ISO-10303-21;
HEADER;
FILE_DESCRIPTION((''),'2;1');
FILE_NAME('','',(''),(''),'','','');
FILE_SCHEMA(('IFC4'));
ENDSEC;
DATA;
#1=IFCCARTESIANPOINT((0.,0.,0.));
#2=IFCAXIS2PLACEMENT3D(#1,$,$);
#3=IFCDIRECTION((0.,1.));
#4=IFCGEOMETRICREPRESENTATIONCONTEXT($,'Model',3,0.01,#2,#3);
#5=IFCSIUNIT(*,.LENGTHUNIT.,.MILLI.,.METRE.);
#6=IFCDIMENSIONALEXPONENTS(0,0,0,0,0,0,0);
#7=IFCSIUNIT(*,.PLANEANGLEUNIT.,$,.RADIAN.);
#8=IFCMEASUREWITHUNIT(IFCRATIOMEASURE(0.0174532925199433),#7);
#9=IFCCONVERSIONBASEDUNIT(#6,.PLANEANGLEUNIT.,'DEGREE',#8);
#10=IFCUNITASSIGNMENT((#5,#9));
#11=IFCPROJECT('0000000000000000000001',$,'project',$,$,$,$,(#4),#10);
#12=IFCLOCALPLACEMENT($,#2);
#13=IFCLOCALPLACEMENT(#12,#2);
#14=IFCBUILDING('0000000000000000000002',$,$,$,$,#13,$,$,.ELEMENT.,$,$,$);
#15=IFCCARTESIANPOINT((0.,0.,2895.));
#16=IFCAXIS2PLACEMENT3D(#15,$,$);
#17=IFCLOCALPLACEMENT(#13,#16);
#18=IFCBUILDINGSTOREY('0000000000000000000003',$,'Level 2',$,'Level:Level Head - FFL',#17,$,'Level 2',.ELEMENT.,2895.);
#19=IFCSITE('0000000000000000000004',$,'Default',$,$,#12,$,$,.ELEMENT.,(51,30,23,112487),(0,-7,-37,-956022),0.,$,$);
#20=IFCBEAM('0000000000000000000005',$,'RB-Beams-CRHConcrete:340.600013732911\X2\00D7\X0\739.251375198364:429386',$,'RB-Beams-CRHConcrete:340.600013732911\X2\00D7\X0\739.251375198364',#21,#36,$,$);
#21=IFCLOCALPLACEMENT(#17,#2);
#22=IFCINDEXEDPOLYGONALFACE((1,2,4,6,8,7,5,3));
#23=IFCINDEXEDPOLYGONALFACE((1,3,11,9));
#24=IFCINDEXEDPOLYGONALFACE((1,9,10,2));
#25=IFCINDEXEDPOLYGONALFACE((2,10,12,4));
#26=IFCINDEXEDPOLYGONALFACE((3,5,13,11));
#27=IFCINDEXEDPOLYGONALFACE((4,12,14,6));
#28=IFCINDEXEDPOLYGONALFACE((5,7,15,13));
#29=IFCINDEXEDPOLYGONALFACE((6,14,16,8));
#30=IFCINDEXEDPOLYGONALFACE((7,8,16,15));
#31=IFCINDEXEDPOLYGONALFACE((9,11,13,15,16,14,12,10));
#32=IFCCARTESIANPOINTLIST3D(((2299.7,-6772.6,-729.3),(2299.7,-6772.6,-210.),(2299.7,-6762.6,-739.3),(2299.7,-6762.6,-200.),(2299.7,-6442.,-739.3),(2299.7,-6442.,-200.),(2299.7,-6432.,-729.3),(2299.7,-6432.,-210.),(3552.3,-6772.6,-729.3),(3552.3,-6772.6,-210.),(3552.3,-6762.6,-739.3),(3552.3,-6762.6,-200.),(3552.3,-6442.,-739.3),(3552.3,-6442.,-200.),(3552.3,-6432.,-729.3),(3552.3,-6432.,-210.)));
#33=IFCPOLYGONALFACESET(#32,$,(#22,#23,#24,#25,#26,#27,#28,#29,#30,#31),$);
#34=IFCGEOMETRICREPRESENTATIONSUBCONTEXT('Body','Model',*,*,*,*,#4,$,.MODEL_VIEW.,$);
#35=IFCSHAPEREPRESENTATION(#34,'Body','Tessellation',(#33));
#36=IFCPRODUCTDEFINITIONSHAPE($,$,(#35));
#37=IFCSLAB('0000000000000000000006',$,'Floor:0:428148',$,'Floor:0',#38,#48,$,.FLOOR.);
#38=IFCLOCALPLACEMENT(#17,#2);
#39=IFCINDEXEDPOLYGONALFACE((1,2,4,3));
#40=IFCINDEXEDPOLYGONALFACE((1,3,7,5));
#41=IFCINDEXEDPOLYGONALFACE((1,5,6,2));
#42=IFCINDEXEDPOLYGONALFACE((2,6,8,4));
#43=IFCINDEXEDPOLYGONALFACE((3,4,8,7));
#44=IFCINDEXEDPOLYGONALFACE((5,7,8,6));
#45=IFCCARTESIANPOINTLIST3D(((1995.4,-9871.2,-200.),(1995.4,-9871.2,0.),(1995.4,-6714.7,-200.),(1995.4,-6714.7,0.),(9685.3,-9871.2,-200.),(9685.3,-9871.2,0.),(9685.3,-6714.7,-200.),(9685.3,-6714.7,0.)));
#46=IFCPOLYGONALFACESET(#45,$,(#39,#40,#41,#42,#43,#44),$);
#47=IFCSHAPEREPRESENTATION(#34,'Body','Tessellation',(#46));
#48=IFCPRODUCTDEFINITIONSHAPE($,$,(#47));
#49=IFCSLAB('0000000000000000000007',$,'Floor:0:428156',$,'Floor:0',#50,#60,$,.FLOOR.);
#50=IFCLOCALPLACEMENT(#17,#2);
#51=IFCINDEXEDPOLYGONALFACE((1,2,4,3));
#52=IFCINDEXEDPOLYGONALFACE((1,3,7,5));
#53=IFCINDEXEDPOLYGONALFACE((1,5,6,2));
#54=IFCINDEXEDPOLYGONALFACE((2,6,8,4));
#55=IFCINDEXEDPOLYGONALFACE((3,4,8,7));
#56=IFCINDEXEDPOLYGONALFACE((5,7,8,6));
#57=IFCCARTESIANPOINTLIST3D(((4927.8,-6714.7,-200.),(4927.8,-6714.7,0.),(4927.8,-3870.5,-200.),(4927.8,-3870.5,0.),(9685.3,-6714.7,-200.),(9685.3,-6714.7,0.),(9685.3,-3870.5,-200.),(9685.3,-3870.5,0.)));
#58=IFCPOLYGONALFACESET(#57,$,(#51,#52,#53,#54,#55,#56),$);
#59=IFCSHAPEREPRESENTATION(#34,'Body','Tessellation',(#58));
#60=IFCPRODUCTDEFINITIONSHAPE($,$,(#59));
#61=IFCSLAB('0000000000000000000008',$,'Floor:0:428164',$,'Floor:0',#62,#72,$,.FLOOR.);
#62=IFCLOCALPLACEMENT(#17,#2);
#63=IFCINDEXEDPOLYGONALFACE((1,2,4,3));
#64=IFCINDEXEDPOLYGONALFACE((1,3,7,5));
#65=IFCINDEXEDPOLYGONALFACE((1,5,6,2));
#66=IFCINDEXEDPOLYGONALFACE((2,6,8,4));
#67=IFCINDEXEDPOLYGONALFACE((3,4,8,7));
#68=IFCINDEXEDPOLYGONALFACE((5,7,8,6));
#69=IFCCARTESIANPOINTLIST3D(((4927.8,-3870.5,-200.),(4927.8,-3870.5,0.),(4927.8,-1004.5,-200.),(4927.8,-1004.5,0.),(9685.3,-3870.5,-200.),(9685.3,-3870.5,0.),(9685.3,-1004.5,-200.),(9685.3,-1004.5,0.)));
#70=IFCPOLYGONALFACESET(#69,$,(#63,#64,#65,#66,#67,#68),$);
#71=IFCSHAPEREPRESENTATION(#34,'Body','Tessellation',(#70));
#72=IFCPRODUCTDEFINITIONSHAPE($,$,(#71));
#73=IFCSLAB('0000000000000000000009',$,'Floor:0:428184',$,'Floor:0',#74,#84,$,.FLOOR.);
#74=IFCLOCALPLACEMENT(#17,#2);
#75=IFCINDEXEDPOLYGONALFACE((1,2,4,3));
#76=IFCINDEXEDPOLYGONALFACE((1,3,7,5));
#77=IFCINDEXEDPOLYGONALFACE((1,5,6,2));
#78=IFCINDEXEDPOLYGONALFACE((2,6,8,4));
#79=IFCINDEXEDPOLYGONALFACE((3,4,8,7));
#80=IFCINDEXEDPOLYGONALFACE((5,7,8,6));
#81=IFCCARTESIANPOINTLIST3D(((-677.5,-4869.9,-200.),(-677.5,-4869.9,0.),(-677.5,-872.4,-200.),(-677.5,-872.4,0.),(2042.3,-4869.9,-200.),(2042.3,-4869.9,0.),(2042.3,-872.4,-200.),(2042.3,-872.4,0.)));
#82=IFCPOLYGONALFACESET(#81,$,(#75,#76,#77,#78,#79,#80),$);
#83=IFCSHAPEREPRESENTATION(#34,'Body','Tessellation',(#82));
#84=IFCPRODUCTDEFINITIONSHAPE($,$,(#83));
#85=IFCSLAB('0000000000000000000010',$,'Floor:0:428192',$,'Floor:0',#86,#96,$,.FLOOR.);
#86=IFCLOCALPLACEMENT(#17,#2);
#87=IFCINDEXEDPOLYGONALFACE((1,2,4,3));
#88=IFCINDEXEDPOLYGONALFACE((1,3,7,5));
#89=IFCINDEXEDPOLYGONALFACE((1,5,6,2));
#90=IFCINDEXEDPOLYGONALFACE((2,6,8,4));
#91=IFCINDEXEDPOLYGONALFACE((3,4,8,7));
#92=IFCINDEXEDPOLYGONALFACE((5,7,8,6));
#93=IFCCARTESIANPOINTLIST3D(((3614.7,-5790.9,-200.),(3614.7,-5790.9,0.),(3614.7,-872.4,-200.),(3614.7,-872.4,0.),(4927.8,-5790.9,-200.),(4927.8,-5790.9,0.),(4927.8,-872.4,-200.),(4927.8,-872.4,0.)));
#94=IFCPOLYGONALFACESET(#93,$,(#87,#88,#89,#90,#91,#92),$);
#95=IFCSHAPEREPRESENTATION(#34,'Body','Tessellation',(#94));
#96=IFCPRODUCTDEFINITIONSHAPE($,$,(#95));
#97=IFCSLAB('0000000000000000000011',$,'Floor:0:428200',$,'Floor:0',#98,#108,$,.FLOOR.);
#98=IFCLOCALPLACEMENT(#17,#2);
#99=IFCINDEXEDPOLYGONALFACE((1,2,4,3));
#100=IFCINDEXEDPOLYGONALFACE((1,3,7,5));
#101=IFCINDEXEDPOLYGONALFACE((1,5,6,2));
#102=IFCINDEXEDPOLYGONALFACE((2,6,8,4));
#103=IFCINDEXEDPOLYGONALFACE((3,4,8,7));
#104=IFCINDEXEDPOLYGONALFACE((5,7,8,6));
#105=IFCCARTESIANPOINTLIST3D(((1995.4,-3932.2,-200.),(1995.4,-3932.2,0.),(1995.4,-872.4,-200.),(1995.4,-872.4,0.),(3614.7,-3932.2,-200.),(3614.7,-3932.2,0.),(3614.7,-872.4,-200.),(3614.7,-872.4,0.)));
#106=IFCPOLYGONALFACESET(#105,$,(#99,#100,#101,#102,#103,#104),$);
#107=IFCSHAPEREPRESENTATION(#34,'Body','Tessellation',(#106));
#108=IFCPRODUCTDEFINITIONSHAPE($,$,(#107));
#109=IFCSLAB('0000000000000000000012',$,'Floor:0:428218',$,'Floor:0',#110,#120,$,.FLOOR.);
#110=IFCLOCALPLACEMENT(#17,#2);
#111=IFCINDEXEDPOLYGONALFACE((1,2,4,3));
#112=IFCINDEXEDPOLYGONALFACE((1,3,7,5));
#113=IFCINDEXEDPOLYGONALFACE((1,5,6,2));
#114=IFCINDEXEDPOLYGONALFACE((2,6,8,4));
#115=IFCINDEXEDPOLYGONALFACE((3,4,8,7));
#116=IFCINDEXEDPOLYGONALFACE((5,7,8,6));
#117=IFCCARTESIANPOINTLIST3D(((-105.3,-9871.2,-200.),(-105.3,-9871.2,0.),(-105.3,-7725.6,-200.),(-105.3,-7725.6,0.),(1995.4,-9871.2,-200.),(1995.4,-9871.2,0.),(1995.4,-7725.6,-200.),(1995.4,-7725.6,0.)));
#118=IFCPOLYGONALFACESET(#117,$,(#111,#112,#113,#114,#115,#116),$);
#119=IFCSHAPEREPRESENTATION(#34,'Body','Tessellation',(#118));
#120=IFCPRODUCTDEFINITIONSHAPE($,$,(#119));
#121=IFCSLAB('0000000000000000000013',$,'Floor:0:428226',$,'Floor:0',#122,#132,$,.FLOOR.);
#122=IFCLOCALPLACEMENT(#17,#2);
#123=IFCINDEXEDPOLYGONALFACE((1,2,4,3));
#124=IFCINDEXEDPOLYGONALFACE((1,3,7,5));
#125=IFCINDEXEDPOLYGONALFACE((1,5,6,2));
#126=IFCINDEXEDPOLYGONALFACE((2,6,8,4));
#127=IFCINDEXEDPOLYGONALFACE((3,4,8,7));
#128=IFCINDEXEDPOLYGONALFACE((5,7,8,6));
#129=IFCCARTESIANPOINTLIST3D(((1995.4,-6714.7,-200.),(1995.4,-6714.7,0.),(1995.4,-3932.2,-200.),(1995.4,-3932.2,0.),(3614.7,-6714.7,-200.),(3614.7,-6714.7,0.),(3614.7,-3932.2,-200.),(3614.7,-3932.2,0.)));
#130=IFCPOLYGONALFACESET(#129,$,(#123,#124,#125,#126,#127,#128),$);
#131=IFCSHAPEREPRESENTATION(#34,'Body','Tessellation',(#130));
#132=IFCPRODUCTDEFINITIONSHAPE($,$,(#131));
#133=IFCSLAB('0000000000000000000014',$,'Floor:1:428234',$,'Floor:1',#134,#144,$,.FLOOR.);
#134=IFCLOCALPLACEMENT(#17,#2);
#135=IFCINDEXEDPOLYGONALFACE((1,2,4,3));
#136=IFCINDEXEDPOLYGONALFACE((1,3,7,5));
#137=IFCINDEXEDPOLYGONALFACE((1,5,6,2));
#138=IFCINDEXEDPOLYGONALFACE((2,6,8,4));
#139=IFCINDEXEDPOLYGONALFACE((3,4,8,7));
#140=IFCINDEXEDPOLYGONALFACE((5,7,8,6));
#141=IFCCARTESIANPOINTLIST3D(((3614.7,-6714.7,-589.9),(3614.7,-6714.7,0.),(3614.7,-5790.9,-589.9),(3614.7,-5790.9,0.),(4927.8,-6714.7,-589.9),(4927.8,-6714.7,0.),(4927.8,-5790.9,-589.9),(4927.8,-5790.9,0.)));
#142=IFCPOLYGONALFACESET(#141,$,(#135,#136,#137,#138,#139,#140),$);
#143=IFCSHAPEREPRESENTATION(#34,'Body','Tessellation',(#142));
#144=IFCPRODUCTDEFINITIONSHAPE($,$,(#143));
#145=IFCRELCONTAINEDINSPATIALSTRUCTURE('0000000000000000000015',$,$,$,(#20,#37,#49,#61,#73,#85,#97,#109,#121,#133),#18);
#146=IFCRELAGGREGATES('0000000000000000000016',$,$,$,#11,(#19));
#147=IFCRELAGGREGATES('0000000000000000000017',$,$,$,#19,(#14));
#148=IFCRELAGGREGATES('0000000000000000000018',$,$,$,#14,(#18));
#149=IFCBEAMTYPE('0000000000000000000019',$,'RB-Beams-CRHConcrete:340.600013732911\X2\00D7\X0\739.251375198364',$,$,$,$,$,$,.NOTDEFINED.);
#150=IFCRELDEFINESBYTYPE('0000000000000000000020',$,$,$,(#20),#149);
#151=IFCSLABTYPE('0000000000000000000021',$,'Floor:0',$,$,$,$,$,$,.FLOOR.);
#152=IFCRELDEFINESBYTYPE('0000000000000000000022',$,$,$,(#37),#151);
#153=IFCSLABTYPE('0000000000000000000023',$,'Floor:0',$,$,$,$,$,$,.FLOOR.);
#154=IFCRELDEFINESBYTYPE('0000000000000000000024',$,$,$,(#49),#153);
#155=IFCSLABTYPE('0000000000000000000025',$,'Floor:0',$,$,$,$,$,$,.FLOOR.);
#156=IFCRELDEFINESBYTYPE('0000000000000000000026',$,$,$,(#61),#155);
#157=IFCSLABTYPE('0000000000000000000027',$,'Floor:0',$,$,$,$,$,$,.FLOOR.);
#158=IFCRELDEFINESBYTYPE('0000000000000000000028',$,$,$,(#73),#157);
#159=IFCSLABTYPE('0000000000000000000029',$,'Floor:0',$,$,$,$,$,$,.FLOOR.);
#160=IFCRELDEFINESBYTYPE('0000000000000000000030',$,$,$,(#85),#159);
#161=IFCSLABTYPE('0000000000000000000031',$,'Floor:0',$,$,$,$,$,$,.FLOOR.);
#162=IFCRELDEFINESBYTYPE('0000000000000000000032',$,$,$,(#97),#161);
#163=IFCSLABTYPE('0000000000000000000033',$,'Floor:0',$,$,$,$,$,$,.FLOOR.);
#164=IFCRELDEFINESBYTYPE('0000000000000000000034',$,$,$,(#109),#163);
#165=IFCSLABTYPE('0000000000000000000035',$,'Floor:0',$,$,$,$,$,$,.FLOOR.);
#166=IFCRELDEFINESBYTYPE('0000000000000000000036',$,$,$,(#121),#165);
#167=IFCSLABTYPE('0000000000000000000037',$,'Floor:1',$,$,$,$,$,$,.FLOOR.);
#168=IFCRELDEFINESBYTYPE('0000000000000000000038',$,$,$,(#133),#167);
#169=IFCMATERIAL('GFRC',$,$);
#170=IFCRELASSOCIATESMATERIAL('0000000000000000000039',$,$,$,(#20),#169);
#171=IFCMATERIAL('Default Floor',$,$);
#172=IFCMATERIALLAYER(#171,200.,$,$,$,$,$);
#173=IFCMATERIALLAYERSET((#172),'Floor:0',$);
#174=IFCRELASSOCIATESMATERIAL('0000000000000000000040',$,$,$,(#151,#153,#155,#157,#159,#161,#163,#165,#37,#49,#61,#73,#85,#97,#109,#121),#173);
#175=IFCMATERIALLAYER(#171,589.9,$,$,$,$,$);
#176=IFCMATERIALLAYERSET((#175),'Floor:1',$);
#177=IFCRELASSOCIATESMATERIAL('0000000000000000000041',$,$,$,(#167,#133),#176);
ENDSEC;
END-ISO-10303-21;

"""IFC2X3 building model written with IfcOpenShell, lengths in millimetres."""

from ifc_helpers import new_model, entity, si_unit, converted_unit, direction, frame, frame_2d, origin, place, context, subcontext, project, spatial, polyline, rectangle, outline, extrude, material, layer, layer_set, layer_usage, type_object, element, save


model = new_model("IFC2X3")

# Units and contexts
model_context = context("Model", 3, precision=0.01, world=origin(), true_north=direction((0.0, 1.0)))
body_context = subcontext(model_context, "Body", "Model", "MODEL_VIEW")
ifc_project = project(units=[si_unit("LENGTHUNIT", "METRE", prefix="MILLI"), converted_unit("PLANEANGLEUNIT", "DEGREE", entity("IfcRatioMeasure", 0.0174532925199433), si_unit("PLANEANGLEUNIT", "RADIAN"), dimensions=[0, 0, 0, 0, 0, 0, 0])], contexts=[model_context])

# Site, building, storey
site_placement = place(None, origin())
site = spatial("IfcSite", under=ifc_project, at=site_placement, Name="Default", CompositionType="ELEMENT", RefLatitude=(51, 30, 23, 112487), RefLongitude=(0, -7, -37, -956022), RefElevation=0.0)
building_placement = place(site_placement, origin())
building = spatial("IfcBuilding", under=site, at=building_placement, CompositionType="ELEMENT")
storey_placement = place(building_placement, frame((0.0, 0.0, 2895.0)))
storey = spatial("IfcBuildingStorey", under=building, at=storey_placement, Name="Level 2", ObjectType="Level:Level Head - FFL", LongName="Level 2", CompositionType="ELEMENT", Elevation=2895.0)

# Beam
ifc_material_1 = material(Name="GFRC")
beam_type_1 = type_object("IfcBeamType", Name="RB-Beams-CRHConcrete:340.600013732911×739.251375198364", PredefinedType="NOTDEFINED")
beam_1_placement = place(storey_placement, frame((2299.7, -6602.3, -200.0)))
element("IfcBeam", 1, at=beam_1_placement, inside=storey, type_object=beam_type_1, material=ifc_material_1, Name="RB-Beams-CRHConcrete:340.600013732911×739.251375198364:429386", ObjectType="RB-Beams-CRHConcrete:340.600013732911×739.251375198364", context=body_context, shape_type="SweptSolid", body=[
    extrude(outline(polyline([(-259.6, -170.3), (259.6, -170.3), (269.6, -160.3), (269.6, 160.3), (259.6, 170.3), (-259.6, 170.3), (-269.6, 160.3), (-269.6, -160.3), (-259.6, -170.3)])), frame((0.0, 0.0, -269.6), z_axis=(1.0, 0.0, 0.0), x_axis=(0.0, 0.0, -1.0)), (0.0, 0.0, 1.0), 1252.6),
])

# Slabs
ifc_material_2 = material(Name="Default Floor")
ifc_layer_1 = layer(ifc_material_2, 200.0)
ifc_layer_set_1 = layer_set([ifc_layer_1], Name="Floor:0")
ifc_layer_usage_1 = layer_usage(ifc_layer_set_1, "AXIS3", "POSITIVE", 0.0)
slab_type_1 = type_object("IfcSlabType", Name="Floor:0", PredefinedType="FLOOR", material=ifc_layer_set_1)
slab_1_placement = place(storey_placement, origin())
element("IfcSlab", 2, at=slab_1_placement, inside=storey, type_object=slab_type_1, material=ifc_layer_usage_1, Name="Floor:0:428148", ObjectType="Floor:0", PredefinedType="FLOOR", context=body_context, shape_type="SweptSolid", body=[
    extrude(rectangle(XDim=3156.5, YDim=7689.9, at=frame_2d((0.0, 0.0), x_axis=(1.0, 0.0))), frame((5840.3, -8293.0, 0.0), z_axis=(0.0, 0.0, -1.0), x_axis=(0.0, 1.0, 0.0)), (0.0, 0.0, 1.0), 200.0),
])
ifc_layer_usage_2 = layer_usage(ifc_layer_set_1, "AXIS3", "POSITIVE", 0.0)
slab_type_2 = type_object("IfcSlabType", Name="Floor:0", PredefinedType="FLOOR", material=ifc_layer_set_1)
slab_2_placement = place(storey_placement, origin())
element("IfcSlab", 3, at=slab_2_placement, inside=storey, type_object=slab_type_2, material=ifc_layer_usage_2, Name="Floor:0:428156", ObjectType="Floor:0", PredefinedType="FLOOR", context=body_context, shape_type="SweptSolid", body=[
    extrude(rectangle(XDim=2844.3, YDim=4757.5, at=frame_2d((0.0, 0.0), x_axis=(1.0, 0.0))), frame((7306.5, -5292.6, 0.0), z_axis=(0.0, 0.0, -1.0), x_axis=(0.0, 1.0, 0.0)), (0.0, 0.0, 1.0), 200.0),
])
ifc_layer_usage_3 = layer_usage(ifc_layer_set_1, "AXIS3", "POSITIVE", 0.0)
slab_type_3 = type_object("IfcSlabType", Name="Floor:0", PredefinedType="FLOOR", material=ifc_layer_set_1)
slab_3_placement = place(storey_placement, origin())
element("IfcSlab", 4, at=slab_3_placement, inside=storey, type_object=slab_type_3, material=ifc_layer_usage_3, Name="Floor:0:428164", ObjectType="Floor:0", PredefinedType="FLOOR", context=body_context, shape_type="SweptSolid", body=[
    extrude(rectangle(XDim=2866.0, YDim=4757.5, at=frame_2d((0.0, 0.0), x_axis=(1.0, 0.0))), frame((7306.5, -2437.5, 0.0), z_axis=(0.0, 0.0, -1.0), x_axis=(0.0, 1.0, 0.0)), (0.0, 0.0, 1.0), 200.0),
])
ifc_layer_2 = layer(ifc_material_2, 589.9)
ifc_layer_set_2 = layer_set([ifc_layer_2], Name="Floor:1")
ifc_layer_usage_4 = layer_usage(ifc_layer_set_1, "AXIS3", "POSITIVE", 0.0)
slab_type_4 = type_object("IfcSlabType", Name="Floor:0", PredefinedType="FLOOR", material=ifc_layer_set_1)
slab_4_placement = place(storey_placement, origin())
element("IfcSlab", 5, at=slab_4_placement, inside=storey, type_object=slab_type_4, material=ifc_layer_usage_4, Name="Floor:0:428184", ObjectType="Floor:0", PredefinedType="FLOOR", context=body_context, shape_type="SweptSolid", body=[
    extrude(rectangle(XDim=3997.6, YDim=2719.8, at=frame_2d((0.0, 0.0), x_axis=(1.0, 0.0))), frame((682.4, -2871.2, 0.0), z_axis=(0.0, 0.0, -1.0), x_axis=(0.0, 1.0, 0.0)), (0.0, 0.0, 1.0), 200.0),
])
ifc_layer_usage_5 = layer_usage(ifc_layer_set_1, "AXIS3", "POSITIVE", 0.0)
slab_type_5 = type_object("IfcSlabType", Name="Floor:0", PredefinedType="FLOOR", material=ifc_layer_set_1)
slab_5_placement = place(storey_placement, origin())
element("IfcSlab", 6, at=slab_5_placement, inside=storey, type_object=slab_type_5, material=ifc_layer_usage_5, Name="Floor:0:428192", ObjectType="Floor:0", PredefinedType="FLOOR", context=body_context, shape_type="SweptSolid", body=[
    extrude(rectangle(XDim=4918.5, YDim=1313.0, at=frame_2d((0.0, 0.0), x_axis=(1.0, 0.0))), frame((4271.2, -3331.6, 0.0), z_axis=(0.0, 0.0, -1.0), x_axis=(0.0, 1.0, 0.0)), (0.0, 0.0, 1.0), 200.0),
])
ifc_layer_usage_6 = layer_usage(ifc_layer_set_1, "AXIS3", "POSITIVE", 0.0)
slab_type_6 = type_object("IfcSlabType", Name="Floor:0", PredefinedType="FLOOR", material=ifc_layer_set_1)
slab_6_placement = place(storey_placement, origin())
element("IfcSlab", 7, at=slab_6_placement, inside=storey, type_object=slab_type_6, material=ifc_layer_usage_6, Name="Floor:0:428200", ObjectType="Floor:0", PredefinedType="FLOOR", context=body_context, shape_type="SweptSolid", body=[
    extrude(rectangle(XDim=3059.8, YDim=1619.3, at=frame_2d((0.0, 0.0), x_axis=(1.0, 0.0))), frame((2805.1, -2402.3, 0.0), z_axis=(0.0, 0.0, -1.0), x_axis=(0.0, 1.0, 0.0)), (0.0, 0.0, 1.0), 200.0),
])
ifc_layer_usage_7 = layer_usage(ifc_layer_set_1, "AXIS3", "POSITIVE", 0.0)
slab_type_7 = type_object("IfcSlabType", Name="Floor:0", PredefinedType="FLOOR", material=ifc_layer_set_1)
slab_7_placement = place(storey_placement, origin())
element("IfcSlab", 8, at=slab_7_placement, inside=storey, type_object=slab_type_7, material=ifc_layer_usage_7, Name="Floor:0:428218", ObjectType="Floor:0", PredefinedType="FLOOR", context=body_context, shape_type="SweptSolid", body=[
    extrude(rectangle(XDim=2145.6, YDim=2100.8, at=frame_2d((0.0, 0.0), x_axis=(1.0, 0.0))), frame((945.0, -8798.4, 0.0), z_axis=(0.0, 0.0, -1.0), x_axis=(0.0, 1.0, 0.0)), (0.0, 0.0, 1.0), 200.0),
])
ifc_layer_usage_8 = layer_usage(ifc_layer_set_1, "AXIS3", "POSITIVE", 0.0)
slab_type_8 = type_object("IfcSlabType", Name="Floor:0", PredefinedType="FLOOR", material=ifc_layer_set_1)
slab_8_placement = place(storey_placement, origin())
element("IfcSlab", 9, at=slab_8_placement, inside=storey, type_object=slab_type_8, material=ifc_layer_usage_8, Name="Floor:0:428226", ObjectType="Floor:0", PredefinedType="FLOOR", context=body_context, shape_type="SweptSolid", body=[
    extrude(rectangle(XDim=2782.6, YDim=1619.3, at=frame_2d((0.0, 0.0), x_axis=(1.0, 0.0))), frame((2805.1, -5323.5, 0.0), z_axis=(0.0, 0.0, -1.0), x_axis=(0.0, 1.0, 0.0)), (0.0, 0.0, 1.0), 200.0),
])
ifc_layer_usage_9 = layer_usage(ifc_layer_set_2, "AXIS3", "POSITIVE", 0.0)
slab_type_9 = type_object("IfcSlabType", Name="Floor:1", PredefinedType="FLOOR", material=ifc_layer_set_2)
slab_9_placement = place(storey_placement, origin())
element("IfcSlab", 10, at=slab_9_placement, inside=storey, type_object=slab_type_9, material=ifc_layer_usage_9, Name="Floor:1:428234", ObjectType="Floor:1", PredefinedType="FLOOR", context=body_context, shape_type="SweptSolid", body=[
    extrude(rectangle(XDim=923.9, YDim=1313.0, at=frame_2d((0.0, 0.0), x_axis=(1.0, 0.0))), frame((4271.2, -6252.8, 0.0), z_axis=(0.0, 0.0, -1.0), x_axis=(0.0, 1.0, 0.0)), (0.0, 0.0, 1.0), 589.9),
])

save(model, "model.ifc")
